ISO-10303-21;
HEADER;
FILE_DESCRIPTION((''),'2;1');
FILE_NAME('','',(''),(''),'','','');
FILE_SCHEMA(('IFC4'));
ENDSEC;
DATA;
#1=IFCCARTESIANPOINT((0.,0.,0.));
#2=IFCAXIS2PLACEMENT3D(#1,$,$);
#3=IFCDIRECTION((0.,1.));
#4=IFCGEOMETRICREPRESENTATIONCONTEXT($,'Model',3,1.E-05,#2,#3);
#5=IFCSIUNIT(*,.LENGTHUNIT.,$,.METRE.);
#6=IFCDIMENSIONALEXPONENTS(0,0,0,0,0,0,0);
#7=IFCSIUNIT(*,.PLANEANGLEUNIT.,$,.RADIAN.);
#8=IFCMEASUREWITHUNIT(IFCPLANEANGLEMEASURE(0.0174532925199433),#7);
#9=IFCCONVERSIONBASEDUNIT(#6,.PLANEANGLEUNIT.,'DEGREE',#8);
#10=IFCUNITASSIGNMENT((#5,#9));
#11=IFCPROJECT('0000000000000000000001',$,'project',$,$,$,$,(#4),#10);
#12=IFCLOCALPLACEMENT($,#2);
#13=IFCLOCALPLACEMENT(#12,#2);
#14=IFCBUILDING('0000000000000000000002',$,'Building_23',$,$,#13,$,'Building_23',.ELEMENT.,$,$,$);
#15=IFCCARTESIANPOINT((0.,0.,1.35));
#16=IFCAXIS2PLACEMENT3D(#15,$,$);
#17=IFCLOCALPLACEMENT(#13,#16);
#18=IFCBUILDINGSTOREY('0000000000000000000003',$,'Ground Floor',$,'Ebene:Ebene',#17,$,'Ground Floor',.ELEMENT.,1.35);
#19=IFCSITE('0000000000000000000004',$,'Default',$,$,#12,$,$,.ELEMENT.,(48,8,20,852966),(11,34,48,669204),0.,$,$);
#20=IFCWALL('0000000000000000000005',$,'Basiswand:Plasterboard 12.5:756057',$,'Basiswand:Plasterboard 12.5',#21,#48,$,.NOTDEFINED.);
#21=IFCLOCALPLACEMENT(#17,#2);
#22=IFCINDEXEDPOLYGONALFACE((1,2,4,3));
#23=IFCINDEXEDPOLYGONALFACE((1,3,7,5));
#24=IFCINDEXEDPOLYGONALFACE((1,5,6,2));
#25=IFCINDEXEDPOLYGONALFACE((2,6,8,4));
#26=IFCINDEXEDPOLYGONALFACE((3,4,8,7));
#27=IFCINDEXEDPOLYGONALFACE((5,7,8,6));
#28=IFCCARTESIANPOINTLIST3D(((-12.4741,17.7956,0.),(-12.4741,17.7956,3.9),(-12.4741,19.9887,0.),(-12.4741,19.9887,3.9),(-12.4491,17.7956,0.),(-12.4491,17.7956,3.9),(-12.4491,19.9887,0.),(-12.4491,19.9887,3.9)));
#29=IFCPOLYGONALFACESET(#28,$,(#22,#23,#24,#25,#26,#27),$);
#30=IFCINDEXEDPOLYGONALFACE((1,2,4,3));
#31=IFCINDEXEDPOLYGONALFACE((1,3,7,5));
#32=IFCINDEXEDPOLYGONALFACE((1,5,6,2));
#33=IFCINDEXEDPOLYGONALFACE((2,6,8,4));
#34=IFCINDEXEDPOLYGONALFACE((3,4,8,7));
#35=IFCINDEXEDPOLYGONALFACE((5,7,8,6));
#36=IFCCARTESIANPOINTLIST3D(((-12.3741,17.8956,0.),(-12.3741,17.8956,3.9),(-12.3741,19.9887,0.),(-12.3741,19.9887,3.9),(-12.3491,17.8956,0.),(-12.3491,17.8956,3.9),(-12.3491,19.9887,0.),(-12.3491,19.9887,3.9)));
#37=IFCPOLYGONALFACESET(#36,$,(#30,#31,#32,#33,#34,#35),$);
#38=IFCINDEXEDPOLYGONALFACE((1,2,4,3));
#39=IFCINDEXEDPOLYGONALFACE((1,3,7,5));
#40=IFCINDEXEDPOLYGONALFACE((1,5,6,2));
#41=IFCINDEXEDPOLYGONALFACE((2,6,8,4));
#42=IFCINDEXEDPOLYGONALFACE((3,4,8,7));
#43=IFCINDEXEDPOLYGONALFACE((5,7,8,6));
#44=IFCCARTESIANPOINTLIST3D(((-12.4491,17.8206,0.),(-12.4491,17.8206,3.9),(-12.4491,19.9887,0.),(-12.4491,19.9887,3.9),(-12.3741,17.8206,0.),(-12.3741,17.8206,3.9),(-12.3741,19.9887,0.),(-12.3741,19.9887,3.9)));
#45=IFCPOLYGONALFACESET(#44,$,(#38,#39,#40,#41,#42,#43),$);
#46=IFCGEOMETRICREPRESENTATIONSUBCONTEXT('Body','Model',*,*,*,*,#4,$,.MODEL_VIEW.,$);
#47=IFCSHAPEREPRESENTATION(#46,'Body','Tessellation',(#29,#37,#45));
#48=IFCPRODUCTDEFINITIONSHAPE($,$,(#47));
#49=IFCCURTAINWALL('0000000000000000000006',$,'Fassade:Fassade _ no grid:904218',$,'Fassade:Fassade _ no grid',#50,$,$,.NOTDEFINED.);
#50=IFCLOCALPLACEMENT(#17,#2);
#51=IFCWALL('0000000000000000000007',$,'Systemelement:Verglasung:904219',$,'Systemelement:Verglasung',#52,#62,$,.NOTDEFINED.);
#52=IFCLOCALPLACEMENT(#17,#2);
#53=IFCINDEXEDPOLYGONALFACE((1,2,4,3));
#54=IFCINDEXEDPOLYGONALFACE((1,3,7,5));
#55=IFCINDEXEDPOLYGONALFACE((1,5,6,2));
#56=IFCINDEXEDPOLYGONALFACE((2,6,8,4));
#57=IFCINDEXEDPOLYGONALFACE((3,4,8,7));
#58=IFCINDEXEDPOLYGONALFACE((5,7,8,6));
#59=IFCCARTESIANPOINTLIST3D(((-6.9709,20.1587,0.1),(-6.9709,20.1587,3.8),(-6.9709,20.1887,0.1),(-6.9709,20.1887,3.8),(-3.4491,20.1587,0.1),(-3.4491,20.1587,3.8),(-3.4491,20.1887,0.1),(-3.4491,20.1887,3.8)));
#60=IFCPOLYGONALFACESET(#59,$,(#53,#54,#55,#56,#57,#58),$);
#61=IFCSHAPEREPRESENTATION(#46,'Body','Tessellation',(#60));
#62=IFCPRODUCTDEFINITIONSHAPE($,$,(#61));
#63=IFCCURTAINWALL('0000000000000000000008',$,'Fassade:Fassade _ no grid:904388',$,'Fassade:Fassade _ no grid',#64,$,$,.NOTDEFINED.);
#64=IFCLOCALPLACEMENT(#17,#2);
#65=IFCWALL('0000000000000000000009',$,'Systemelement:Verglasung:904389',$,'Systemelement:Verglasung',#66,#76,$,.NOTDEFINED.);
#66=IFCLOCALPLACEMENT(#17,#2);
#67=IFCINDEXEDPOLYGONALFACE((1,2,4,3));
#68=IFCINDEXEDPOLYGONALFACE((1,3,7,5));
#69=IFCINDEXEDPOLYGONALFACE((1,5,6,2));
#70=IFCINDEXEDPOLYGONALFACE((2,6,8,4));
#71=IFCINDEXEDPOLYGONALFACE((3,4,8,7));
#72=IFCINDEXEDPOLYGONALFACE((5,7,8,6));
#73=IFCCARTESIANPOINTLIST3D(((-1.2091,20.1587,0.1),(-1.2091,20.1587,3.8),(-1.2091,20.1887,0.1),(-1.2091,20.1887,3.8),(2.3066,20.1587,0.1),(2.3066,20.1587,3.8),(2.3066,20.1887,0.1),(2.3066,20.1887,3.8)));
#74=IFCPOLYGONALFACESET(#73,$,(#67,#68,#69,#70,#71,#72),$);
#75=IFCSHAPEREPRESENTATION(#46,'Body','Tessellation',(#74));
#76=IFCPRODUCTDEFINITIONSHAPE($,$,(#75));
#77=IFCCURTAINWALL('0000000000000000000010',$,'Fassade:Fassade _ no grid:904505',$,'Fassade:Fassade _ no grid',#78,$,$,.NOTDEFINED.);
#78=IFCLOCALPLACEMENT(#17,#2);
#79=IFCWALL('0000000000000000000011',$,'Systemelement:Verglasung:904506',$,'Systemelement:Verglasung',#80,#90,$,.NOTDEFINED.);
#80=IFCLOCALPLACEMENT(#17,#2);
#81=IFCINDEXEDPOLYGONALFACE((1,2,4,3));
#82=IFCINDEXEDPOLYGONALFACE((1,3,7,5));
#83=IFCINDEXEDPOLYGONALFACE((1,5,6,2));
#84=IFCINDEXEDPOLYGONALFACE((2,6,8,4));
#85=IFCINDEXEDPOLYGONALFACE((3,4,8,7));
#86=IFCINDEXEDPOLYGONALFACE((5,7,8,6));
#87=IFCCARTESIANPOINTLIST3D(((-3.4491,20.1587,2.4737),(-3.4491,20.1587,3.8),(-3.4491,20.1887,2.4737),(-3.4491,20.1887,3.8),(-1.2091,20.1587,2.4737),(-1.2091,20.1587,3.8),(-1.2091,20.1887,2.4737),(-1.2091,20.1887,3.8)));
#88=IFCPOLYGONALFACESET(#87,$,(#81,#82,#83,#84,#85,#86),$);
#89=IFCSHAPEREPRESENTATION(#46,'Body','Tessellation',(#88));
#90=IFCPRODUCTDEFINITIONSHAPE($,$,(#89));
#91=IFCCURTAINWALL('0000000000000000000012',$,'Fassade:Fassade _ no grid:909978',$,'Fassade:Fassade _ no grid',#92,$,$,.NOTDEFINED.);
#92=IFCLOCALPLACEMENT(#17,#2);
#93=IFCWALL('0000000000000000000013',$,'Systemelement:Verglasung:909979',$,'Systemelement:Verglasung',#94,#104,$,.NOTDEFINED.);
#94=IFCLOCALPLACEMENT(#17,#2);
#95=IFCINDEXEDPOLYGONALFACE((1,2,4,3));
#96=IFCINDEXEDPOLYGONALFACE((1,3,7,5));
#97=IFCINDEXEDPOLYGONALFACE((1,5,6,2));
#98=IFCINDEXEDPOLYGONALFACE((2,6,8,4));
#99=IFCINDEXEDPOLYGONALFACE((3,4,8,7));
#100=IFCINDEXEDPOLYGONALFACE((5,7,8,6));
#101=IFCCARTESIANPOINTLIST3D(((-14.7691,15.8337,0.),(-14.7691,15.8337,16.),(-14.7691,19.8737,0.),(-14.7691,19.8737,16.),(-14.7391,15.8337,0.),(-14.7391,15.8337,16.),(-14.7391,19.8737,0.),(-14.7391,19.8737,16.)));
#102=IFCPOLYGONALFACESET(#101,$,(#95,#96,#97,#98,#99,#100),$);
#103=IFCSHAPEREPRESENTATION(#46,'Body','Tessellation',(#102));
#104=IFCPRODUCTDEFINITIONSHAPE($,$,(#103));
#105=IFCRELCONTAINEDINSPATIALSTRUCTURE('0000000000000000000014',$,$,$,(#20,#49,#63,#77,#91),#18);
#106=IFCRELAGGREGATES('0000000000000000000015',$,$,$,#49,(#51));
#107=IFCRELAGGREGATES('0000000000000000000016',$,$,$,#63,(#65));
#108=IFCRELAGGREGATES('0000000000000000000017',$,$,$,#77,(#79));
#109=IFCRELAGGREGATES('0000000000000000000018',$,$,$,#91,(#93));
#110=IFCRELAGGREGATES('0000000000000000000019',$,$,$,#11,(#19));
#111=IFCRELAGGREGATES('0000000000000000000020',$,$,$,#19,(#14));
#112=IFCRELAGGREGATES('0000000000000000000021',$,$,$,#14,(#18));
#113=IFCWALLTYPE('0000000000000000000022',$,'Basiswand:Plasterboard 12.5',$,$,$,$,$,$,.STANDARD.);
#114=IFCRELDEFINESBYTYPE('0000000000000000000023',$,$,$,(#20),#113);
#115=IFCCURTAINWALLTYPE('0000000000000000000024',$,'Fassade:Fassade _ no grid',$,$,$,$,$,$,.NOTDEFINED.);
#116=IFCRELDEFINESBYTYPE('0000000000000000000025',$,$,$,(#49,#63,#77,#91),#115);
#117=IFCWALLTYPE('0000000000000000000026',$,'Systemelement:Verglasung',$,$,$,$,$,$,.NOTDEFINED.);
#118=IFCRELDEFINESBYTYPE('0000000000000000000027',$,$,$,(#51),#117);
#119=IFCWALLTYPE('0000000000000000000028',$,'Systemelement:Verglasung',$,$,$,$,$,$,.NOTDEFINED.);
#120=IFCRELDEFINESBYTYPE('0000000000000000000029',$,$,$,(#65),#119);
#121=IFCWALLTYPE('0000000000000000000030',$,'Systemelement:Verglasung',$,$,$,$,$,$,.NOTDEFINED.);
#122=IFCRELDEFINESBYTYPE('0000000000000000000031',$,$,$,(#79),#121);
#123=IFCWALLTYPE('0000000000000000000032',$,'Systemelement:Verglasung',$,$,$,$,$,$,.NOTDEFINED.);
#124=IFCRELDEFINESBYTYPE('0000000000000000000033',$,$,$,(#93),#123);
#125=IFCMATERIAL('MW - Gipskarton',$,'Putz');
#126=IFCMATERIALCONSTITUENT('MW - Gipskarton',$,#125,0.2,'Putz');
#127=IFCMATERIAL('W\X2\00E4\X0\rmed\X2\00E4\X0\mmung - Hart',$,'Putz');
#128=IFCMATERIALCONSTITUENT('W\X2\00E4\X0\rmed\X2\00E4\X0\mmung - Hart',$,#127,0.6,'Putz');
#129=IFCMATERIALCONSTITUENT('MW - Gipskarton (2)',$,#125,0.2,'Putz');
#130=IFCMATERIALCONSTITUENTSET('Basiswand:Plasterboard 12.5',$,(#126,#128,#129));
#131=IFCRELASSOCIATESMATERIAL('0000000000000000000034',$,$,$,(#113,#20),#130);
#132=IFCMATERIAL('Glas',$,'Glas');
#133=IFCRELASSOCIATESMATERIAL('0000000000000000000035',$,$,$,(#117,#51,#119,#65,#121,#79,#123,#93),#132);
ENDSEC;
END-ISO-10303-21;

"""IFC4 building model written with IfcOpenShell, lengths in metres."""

from ifc_helpers import new_model, entity, si_unit, converted_unit, direction, frame, origin, place, context, subcontext, project, spatial, indexed_curve, outline, extrude, source, transform, mapped, material, constituent, constituent_set, type_object, type_shapes, element, aggregate, save


model = new_model("IFC4")

# Units and contexts
model_context = context("Model", 3, precision=1e-05, world=origin(), true_north=direction((0.0, 1.0)))
body_context = subcontext(model_context, "Body", "Model", "MODEL_VIEW")
ifc_project = project(units=[si_unit("LENGTHUNIT", "METRE"), converted_unit("PLANEANGLEUNIT", "DEGREE", entity("IfcPlaneAngleMeasure", 0.0174532925199433), si_unit("PLANEANGLEUNIT", "RADIAN"), dimensions=[0, 0, 0, 0, 0, 0, 0])], contexts=[model_context])

# Site, building, storey
site_placement = place(None, origin())
site = spatial("IfcSite", under=ifc_project, at=site_placement, Name="Default", CompositionType="ELEMENT", RefLatitude=(48, 8, 20, 852966), RefLongitude=(11, 34, 48, 669204), RefElevation=0.0)
building_placement = place(site_placement, origin())
building = spatial("IfcBuilding", under=site, at=building_placement, Name="Building_23", LongName="Building_23", CompositionType="ELEMENT")
storey_placement = place(building_placement, frame((0.0, 0.0, 1.35)))
storey = spatial("IfcBuildingStorey", under=building, at=storey_placement, Name="Ground Floor", ObjectType="Ebene:Ebene", LongName="Ground Floor", CompositionType="ELEMENT", Elevation=1.35)

# Wall, opening
ifc_material_1 = material(Name="MW - Gipskarton", Category="Putz")
ifc_constituent_1 = constituent(ifc_material_1, Name="MW - Gipskarton", Category="Putz", fraction=0.2)
ifc_material_2 = material(Name="Wärmedämmung - Hart", Category="Putz")
ifc_constituent_2 = constituent(ifc_material_2, Name="Wärmedämmung - Hart", Category="Putz", fraction=0.6)
ifc_constituent_3 = constituent(ifc_material_1, Name="MW - Gipskarton (2)", Category="Putz", fraction=0.2)
ifc_constituent_set_1 = constituent_set(constituents=[ifc_constituent_1, ifc_constituent_2, ifc_constituent_3], Name="Basiswand:Plasterboard 12.5")
wall_type_1 = type_object("IfcWallType", Name="Basiswand:Plasterboard 12.5", PredefinedType="STANDARD", material=ifc_constituent_set_1)
wall_1_placement = place(storey_placement, frame((-12.4116, 19.9737, 0.0), z_axis=(0.0, 0.0, 1.0), x_axis=(0.0, -1.0, 0.0)))
wall_1 = element("IfcWall", 1, at=wall_1_placement, inside=storey, type_object=wall_type_1, material=ifc_constituent_set_1, Name="Basiswand:Plasterboard 12.5:756057", ObjectType="Basiswand:Plasterboard 12.5", PredefinedType="NOTDEFINED", context=body_context, shape_type="SweptSolid", body=[
    extrude(outline(indexed_curve([(-1.95, -1.0965), (1.95, -1.0965), (1.95, 1.0965), (-1.95, 1.0965), (-1.95, -1.0965)], self_intersect=False)), frame((1.0815, -0.0625, 1.95), z_axis=(0.0, 1.0, 0.0), x_axis=(0.0, 0.0, 1.0)), (0.0, 0.0, 1.0), 0.025),
    extrude(outline(indexed_curve([(-1.95, -1.0465), (1.95, -1.0465), (1.95, 1.0465), (-1.95, 1.0465), (-1.95, -1.0465)], self_intersect=False)), frame((1.0315, 0.0375, 1.95), z_axis=(0.0, 1.0, 0.0), x_axis=(0.0, 0.0, 1.0)), (0.0, 0.0, 1.0), 0.025),
    extrude(outline(indexed_curve([(-1.95, -1.084), (1.95, -1.084), (1.95, 1.084), (-1.95, 1.084), (-1.95, -1.084)], self_intersect=False)), frame((1.069, -0.0375, 1.95), z_axis=(0.0, 1.0, 0.0), x_axis=(0.0, 0.0, 1.0)), (0.0, 0.0, 1.0), 0.075),
])
opening_1_placement = place(wall_1_placement, origin())
element("IfcOpeningElement", 2, at=opening_1_placement, cuts=wall_1, PredefinedType="OPENING", context=body_context, shape_type="SweptSolid", body=[
    extrude(outline(indexed_curve([(-0.0625, -1.18), (0.0625, -1.18), (0.0625, 1.18), (-0.0625, 1.18), (-0.0625, -1.18)], self_intersect=False)), frame((2.1156, 0.0625, 1.18), z_axis=(0.0, 1.0, 0.0), x_axis=(1.0, 0.0, 0.0)), (0.0, 0.0, 1.0), 1.0),
])

# Curtain walls, walls
curtain_wall_type = type_object("IfcCurtainWallType", Name="Fassade:Fassade _ no grid", PredefinedType="NOTDEFINED")
curtain_wall_1_placement = place(storey_placement, frame((0.0, 0.0, -1.35)))
curtain_wall_1 = element("IfcCurtainWall", 3, at=curtain_wall_1_placement, inside=storey, type_object=curtain_wall_type, Name="Fassade:Fassade _ no grid:904218", ObjectType="Fassade:Fassade _ no grid", PredefinedType="NOTDEFINED")
ifc_material_3 = material(Name="Glas", Category="Glas")
wall_type_2 = type_object("IfcWallType", Name="Systemelement:Verglasung", PredefinedType="NOTDEFINED", material=ifc_material_3)
shared_shape_1 = source(origin(), body_context, "Body", "SweptSolid", [
    extrude(outline(indexed_curve([(-0.015, -1.7609), (0.015, -1.7609), (0.015, 1.7609), (-0.015, 1.7609), (-0.015, -1.7609)], self_intersect=False)), frame((0.0, 0.0, 0.0), z_axis=(0.0, 0.0, 1.0), x_axis=(0.0, 1.0, 0.0)), (0.0, 0.0, 1.0), 3.7),
])
type_shapes(wall_type_2, [shared_shape_1])
wall_2_placement = place(storey_placement, frame((-5.21, 20.1737, 0.1)))
wall_2 = element("IfcWall", 4, at=wall_2_placement, type_object=wall_type_2, material=ifc_material_3, Name="Systemelement:Verglasung:904219", ObjectType="Systemelement:Verglasung", PredefinedType="NOTDEFINED", context=body_context, shape_type="MappedRepresentation", body=[
    mapped(shared_shape_1, transform((0.0, 0.0, 0.0), scale=1.0)),
])
aggregate(curtain_wall_1, [wall_2])
curtain_wall_2_placement = place(storey_placement, frame((0.0, 0.0, -1.35)))
curtain_wall_2 = element("IfcCurtainWall", 5, at=curtain_wall_2_placement, inside=storey, type_object=curtain_wall_type, Name="Fassade:Fassade _ no grid:904388", ObjectType="Fassade:Fassade _ no grid", PredefinedType="NOTDEFINED")
wall_type_3 = type_object("IfcWallType", Name="Systemelement:Verglasung", PredefinedType="NOTDEFINED", material=ifc_material_3)
shared_shape_2 = source(origin(), body_context, "Body", "SweptSolid", [
    extrude(outline(indexed_curve([(-0.015, -1.7579), (0.015, -1.7579), (0.015, 1.7579), (-0.015, 1.7579), (-0.015, -1.7579)], self_intersect=False)), frame((0.0, 0.0, 0.0), z_axis=(0.0, 0.0, 1.0), x_axis=(0.0, 1.0, 0.0)), (0.0, 0.0, 1.0), 3.7),
])
type_shapes(wall_type_3, [shared_shape_2])
wall_3_placement = place(storey_placement, frame((0.5488, 20.1737, 0.1)))
wall_3 = element("IfcWall", 6, at=wall_3_placement, type_object=wall_type_3, material=ifc_material_3, Name="Systemelement:Verglasung:904389", ObjectType="Systemelement:Verglasung", PredefinedType="NOTDEFINED", context=body_context, shape_type="MappedRepresentation", body=[
    mapped(shared_shape_2, transform((0.0, 0.0, 0.0), scale=1.0)),
])
aggregate(curtain_wall_2, [wall_3])
curtain_wall_3_placement = place(storey_placement, frame((0.0, 0.0, -1.35)))
curtain_wall_3 = element("IfcCurtainWall", 7, at=curtain_wall_3_placement, inside=storey, type_object=curtain_wall_type, Name="Fassade:Fassade _ no grid:904505", ObjectType="Fassade:Fassade _ no grid", PredefinedType="NOTDEFINED")
wall_type_4 = type_object("IfcWallType", Name="Systemelement:Verglasung", PredefinedType="NOTDEFINED", material=ifc_material_3)
shared_shape_3 = source(origin(), body_context, "Body", "SweptSolid", [
    extrude(outline(indexed_curve([(-0.015, -1.12), (0.015, -1.12), (0.015, 1.12), (-0.015, 1.12), (-0.015, -1.12)], self_intersect=False)), frame((0.0, 0.0, 0.0), z_axis=(0.0, 0.0, 1.0), x_axis=(0.0, 1.0, 0.0)), (0.0, 0.0, 1.0), 1.3263),
])
type_shapes(wall_type_4, [shared_shape_3])
wall_4_placement = place(storey_placement, frame((-2.3291, 20.1737, 2.4737)))
wall_4 = element("IfcWall", 8, at=wall_4_placement, type_object=wall_type_4, material=ifc_material_3, Name="Systemelement:Verglasung:904506", ObjectType="Systemelement:Verglasung", PredefinedType="NOTDEFINED", context=body_context, shape_type="MappedRepresentation", body=[
    mapped(shared_shape_3, transform((0.0, 0.0, 0.0), scale=1.0)),
])
aggregate(curtain_wall_3, [wall_4])
curtain_wall_4_placement = place(storey_placement, frame((0.0, 0.0, -1.35)))
curtain_wall_4 = element("IfcCurtainWall", 9, at=curtain_wall_4_placement, inside=storey, type_object=curtain_wall_type, Name="Fassade:Fassade _ no grid:909978", ObjectType="Fassade:Fassade _ no grid", PredefinedType="NOTDEFINED")
wall_type_5 = type_object("IfcWallType", Name="Systemelement:Verglasung", PredefinedType="NOTDEFINED", material=ifc_material_3)
shared_shape_4 = source(origin(), body_context, "Body", "SweptSolid", [
    extrude(outline(indexed_curve([(-0.015, -2.02), (0.015, -2.02), (0.015, 2.02), (-0.015, 2.02), (-0.015, -2.02)], self_intersect=False)), frame((0.0, 0.0, 0.0), z_axis=(0.0, 0.0, 1.0), x_axis=(0.0, 1.0, 0.0)), (0.0, 0.0, 1.0), 16.0),
])
type_shapes(wall_type_5, [shared_shape_4])
wall_5_placement = place(storey_placement, frame((-14.7541, 17.8537, 0.0), z_axis=(0.0, 0.0, 1.0), x_axis=(0.0, -1.0, 0.0)))
wall_5 = element("IfcWall", 10, at=wall_5_placement, type_object=wall_type_5, material=ifc_material_3, Name="Systemelement:Verglasung:909979", ObjectType="Systemelement:Verglasung", PredefinedType="NOTDEFINED", context=body_context, shape_type="MappedRepresentation", body=[
    mapped(shared_shape_4, transform((0.0, 0.0, 0.0), scale=1.0)),
])
aggregate(curtain_wall_4, [wall_5])

save(model, "model.ifc")
